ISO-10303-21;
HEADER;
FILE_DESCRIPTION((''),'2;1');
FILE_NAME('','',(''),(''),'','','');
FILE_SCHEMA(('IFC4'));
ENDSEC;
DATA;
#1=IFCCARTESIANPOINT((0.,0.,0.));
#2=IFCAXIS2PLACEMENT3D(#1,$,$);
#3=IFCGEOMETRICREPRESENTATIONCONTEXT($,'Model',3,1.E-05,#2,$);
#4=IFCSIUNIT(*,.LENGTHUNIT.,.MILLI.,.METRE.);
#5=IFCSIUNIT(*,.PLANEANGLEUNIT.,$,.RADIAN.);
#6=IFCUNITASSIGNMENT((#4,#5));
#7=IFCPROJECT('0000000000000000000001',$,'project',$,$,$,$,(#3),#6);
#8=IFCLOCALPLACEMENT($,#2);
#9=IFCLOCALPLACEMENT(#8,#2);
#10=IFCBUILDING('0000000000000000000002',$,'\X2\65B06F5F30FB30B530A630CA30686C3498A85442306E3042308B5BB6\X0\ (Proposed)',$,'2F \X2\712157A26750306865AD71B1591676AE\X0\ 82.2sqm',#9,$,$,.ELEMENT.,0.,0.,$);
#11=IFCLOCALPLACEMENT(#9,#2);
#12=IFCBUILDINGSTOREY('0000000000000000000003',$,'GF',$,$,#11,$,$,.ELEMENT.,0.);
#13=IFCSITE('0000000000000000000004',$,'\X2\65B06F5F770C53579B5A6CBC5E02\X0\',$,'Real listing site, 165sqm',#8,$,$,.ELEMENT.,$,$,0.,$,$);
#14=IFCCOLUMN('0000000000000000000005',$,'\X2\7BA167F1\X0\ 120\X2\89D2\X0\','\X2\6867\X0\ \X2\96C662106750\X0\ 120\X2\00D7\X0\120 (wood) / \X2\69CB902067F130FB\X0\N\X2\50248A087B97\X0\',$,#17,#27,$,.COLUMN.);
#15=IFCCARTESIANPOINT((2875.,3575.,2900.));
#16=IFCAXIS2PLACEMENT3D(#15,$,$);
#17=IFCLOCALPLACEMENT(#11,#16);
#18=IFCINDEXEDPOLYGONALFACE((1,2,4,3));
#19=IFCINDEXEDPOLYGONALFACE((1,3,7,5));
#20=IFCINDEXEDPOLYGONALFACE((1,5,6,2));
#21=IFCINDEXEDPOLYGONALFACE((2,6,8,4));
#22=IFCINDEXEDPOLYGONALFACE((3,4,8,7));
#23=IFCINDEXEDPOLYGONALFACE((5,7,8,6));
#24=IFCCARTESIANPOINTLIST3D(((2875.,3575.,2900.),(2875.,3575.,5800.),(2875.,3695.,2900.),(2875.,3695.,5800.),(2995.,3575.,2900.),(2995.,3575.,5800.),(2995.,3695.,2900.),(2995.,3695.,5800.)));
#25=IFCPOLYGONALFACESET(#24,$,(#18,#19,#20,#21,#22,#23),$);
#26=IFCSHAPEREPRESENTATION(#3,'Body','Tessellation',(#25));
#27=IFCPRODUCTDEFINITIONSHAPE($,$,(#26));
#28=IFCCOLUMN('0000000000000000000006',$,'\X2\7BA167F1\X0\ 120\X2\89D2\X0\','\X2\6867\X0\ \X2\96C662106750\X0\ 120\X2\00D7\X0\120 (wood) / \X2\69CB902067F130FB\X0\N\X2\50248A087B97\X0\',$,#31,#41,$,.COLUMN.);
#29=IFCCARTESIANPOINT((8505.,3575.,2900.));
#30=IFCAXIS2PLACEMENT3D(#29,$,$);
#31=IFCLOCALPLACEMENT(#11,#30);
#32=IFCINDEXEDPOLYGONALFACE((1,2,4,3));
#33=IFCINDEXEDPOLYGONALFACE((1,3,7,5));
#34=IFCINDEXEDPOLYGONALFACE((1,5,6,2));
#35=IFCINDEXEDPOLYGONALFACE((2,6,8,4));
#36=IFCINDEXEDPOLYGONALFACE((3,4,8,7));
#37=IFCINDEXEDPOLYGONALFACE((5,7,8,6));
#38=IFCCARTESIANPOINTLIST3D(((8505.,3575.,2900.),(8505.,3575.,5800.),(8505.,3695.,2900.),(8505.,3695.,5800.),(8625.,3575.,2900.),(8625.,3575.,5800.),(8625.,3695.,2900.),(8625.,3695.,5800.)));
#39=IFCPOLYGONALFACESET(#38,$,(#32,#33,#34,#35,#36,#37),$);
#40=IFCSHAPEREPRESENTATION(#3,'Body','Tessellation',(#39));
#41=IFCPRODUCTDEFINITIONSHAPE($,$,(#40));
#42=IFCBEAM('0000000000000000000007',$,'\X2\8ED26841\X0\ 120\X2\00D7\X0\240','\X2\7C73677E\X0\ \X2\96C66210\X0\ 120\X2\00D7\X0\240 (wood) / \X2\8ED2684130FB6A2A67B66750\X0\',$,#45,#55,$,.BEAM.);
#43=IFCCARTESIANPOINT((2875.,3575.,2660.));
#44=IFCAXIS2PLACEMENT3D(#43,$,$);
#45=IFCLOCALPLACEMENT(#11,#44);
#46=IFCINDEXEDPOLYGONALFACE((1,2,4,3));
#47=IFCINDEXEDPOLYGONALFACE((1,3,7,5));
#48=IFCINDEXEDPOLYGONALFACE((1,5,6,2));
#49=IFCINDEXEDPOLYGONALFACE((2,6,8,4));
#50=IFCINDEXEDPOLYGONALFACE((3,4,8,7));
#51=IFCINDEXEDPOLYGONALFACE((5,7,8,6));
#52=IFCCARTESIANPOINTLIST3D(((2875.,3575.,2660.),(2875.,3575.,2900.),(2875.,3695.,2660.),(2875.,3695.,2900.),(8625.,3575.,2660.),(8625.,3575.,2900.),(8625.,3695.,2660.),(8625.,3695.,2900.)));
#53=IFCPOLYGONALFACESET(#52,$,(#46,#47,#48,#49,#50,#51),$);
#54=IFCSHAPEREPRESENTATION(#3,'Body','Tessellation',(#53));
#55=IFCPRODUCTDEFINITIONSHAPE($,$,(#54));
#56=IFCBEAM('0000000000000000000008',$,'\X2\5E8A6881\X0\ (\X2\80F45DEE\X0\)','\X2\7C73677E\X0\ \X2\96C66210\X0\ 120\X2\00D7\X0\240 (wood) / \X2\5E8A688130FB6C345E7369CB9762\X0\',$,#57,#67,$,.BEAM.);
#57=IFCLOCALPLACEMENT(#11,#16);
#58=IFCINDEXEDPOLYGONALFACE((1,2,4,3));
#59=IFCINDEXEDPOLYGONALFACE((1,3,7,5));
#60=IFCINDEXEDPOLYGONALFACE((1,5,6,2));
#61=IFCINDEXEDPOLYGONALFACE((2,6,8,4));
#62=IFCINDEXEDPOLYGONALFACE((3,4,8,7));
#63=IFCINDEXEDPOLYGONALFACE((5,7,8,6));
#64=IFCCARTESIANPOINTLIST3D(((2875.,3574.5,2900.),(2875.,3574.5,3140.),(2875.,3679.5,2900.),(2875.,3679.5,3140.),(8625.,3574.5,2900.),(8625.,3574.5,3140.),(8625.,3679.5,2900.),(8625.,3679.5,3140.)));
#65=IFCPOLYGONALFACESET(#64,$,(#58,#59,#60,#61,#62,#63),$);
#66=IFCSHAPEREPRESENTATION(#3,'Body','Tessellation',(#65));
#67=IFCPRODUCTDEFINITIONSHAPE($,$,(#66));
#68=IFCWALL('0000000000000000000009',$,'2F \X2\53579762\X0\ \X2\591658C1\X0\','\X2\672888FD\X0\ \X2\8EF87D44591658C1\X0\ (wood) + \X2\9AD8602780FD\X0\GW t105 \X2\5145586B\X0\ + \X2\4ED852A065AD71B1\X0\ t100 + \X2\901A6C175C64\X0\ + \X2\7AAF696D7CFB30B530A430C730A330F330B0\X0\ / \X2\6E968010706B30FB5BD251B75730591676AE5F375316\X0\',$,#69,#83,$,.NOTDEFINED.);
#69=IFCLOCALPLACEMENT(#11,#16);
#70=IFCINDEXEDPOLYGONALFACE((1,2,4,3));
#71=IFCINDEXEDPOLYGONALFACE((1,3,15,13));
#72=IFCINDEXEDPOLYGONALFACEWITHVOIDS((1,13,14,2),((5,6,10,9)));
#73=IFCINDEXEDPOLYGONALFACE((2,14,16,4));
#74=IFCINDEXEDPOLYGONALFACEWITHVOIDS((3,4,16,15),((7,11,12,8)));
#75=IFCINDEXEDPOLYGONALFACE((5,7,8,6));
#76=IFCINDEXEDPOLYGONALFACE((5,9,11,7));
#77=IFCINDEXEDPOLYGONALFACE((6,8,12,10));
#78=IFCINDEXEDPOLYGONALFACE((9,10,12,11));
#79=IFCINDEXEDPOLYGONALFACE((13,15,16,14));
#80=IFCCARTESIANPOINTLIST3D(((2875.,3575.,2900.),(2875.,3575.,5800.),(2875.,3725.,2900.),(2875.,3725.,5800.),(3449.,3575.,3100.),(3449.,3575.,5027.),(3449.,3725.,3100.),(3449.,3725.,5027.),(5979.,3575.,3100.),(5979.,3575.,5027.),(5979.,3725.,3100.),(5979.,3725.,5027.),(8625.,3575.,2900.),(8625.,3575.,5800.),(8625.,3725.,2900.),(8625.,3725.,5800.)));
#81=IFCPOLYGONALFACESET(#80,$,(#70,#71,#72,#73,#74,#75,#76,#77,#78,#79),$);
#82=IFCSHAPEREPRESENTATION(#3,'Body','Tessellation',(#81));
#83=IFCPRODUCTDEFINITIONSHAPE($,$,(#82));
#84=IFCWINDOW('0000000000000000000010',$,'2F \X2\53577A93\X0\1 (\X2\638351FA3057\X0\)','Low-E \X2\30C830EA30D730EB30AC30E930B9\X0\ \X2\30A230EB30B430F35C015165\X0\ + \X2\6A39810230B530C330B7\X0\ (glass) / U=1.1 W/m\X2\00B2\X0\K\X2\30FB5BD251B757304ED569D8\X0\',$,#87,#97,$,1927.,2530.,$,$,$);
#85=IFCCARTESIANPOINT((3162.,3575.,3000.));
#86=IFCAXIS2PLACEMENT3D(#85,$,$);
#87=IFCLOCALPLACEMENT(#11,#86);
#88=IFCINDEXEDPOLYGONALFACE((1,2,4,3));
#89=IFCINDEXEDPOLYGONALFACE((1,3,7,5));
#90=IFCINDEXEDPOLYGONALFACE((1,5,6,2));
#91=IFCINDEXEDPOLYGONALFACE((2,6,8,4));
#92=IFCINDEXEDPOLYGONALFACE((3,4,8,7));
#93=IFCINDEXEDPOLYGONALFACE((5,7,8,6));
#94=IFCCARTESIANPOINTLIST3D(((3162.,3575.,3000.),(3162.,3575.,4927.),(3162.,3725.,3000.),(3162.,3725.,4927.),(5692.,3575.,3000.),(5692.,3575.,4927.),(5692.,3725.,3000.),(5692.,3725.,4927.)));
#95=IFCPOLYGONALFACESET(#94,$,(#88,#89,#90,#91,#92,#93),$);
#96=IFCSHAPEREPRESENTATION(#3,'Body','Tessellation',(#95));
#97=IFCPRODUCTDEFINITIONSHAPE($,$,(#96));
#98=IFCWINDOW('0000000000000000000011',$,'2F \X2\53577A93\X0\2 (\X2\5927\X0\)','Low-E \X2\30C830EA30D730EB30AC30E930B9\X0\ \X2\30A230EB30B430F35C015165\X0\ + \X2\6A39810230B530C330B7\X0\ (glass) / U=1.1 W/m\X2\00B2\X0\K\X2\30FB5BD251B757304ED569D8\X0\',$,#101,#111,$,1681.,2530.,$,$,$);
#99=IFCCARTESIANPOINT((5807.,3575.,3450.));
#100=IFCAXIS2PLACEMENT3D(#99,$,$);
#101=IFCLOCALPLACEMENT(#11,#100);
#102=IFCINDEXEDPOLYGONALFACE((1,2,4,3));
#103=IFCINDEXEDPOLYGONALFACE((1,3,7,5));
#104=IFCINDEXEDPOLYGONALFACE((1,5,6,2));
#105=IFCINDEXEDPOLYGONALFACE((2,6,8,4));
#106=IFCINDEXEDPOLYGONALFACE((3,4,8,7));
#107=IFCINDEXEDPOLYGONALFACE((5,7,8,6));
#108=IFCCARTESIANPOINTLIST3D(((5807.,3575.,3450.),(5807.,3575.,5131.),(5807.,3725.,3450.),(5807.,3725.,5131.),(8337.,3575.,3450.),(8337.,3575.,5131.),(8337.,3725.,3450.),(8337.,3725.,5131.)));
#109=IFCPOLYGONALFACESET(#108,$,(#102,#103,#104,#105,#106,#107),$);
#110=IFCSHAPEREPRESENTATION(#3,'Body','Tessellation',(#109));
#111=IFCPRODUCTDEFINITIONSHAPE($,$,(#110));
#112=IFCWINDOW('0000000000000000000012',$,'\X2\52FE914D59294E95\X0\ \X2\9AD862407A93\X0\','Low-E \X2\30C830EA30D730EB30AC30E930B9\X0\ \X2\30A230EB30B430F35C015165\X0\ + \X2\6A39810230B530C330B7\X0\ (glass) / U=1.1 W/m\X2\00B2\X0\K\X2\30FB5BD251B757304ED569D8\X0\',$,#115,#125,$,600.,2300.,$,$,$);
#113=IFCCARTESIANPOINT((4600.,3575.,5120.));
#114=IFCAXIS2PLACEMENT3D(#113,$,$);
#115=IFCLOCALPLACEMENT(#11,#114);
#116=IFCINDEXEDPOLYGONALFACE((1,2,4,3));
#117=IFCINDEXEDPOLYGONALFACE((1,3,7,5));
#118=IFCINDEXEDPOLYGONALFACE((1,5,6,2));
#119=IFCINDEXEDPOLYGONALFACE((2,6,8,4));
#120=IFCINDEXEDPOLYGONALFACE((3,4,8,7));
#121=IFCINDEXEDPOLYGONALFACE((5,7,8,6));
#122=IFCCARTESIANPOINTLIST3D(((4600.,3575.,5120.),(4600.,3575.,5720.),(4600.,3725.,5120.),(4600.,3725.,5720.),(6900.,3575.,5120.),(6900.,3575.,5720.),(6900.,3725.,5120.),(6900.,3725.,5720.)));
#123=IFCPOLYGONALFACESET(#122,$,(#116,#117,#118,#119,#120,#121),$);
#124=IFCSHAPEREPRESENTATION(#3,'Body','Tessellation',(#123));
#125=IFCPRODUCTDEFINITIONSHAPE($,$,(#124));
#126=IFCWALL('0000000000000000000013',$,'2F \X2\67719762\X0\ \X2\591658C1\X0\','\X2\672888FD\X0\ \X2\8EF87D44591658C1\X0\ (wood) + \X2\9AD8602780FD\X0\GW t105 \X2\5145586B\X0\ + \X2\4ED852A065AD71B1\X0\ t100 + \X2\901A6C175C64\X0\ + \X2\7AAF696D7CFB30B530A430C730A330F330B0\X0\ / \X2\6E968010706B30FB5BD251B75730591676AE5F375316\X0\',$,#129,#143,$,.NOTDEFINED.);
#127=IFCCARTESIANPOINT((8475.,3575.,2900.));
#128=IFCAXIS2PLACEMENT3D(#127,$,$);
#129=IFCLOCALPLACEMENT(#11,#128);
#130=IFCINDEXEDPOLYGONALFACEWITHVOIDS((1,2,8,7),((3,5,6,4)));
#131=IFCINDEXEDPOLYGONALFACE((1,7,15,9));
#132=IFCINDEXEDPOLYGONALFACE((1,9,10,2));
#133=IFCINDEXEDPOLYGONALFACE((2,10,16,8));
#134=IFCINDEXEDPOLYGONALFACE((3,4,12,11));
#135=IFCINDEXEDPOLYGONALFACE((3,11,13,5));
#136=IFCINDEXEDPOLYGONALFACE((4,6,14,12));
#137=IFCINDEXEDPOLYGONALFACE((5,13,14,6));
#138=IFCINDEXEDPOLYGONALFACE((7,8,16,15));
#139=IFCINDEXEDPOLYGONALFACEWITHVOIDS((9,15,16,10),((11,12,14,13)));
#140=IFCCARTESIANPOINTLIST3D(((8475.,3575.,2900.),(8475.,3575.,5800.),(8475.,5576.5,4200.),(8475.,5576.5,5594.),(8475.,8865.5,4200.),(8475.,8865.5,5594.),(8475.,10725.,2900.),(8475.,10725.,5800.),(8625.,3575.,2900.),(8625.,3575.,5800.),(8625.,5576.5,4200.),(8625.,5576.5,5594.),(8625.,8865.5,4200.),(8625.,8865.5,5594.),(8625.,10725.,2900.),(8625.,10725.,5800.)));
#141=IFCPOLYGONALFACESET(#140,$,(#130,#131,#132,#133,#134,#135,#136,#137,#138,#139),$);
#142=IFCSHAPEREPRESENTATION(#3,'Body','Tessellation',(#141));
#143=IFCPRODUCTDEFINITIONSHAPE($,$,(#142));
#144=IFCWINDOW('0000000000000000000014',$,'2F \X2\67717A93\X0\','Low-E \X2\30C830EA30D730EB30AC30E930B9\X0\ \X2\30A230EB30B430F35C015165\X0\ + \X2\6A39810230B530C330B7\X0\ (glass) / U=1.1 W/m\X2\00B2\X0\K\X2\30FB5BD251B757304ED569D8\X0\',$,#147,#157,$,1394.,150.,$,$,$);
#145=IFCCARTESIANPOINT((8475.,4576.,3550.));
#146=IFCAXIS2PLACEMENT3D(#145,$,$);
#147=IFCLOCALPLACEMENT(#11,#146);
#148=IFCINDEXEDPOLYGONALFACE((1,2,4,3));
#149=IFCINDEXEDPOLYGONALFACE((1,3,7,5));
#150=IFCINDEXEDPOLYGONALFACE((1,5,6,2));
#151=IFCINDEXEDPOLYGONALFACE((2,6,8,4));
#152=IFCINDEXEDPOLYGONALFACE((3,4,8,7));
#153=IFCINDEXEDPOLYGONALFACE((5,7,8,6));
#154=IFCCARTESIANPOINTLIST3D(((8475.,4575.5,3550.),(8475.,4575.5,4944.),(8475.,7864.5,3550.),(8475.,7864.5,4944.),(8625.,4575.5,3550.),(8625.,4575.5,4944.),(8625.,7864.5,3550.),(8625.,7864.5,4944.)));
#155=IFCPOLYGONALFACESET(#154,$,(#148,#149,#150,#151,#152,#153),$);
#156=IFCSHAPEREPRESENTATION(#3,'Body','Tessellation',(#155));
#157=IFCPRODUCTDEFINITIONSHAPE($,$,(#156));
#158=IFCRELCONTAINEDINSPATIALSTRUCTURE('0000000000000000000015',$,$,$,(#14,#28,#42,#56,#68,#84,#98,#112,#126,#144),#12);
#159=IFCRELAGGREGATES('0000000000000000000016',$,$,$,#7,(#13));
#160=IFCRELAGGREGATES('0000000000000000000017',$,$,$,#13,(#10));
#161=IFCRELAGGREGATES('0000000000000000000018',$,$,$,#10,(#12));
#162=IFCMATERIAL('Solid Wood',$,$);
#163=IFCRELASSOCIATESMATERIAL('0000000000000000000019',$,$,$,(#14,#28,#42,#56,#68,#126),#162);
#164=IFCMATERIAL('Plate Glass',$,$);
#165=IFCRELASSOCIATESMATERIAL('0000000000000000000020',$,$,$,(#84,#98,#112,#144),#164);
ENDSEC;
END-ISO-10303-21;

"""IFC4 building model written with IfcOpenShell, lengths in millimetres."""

from ifc_helpers import new_model, si_unit, frame, frame_2d, origin, place, context, project, spatial, rectangle, extrude, material, element, fill, save


model = new_model("IFC4")

# Units and contexts
model_context = context("Model", 3, precision=1e-05, world=origin())
ifc_project = project(units=[si_unit("LENGTHUNIT", "METRE", prefix="MILLI"), si_unit("PLANEANGLEUNIT", "RADIAN")], contexts=[model_context])

# Site, building, storey
site_placement = place(None, origin())
site = spatial("IfcSite", under=ifc_project, at=site_placement, Name="新潟県南魚沼市", ObjectType="Real listing site, 165sqm", CompositionType="ELEMENT", RefElevation=0.0)
building_placement = place(site_placement, origin())
building = spatial("IfcBuilding", under=site, at=building_placement, Name="新潟・サウナと水風呂のある家 (Proposed)", ObjectType="2F 無垢材と断熱外皮 82.2sqm", CompositionType="ELEMENT", ElevationOfRefHeight=0.0, ElevationOfTerrain=0.0)
storey_placement = place(building_placement, origin())
storey = spatial("IfcBuildingStorey", under=building, at=storey_placement, Name="GF", CompositionType="ELEMENT", Elevation=0.0)

# Columns
ifc_material_1 = material(Name="Solid Wood")
column_1_placement = place(storey_placement, frame((2875.0, 3575.0, 2900.0)))
element("IfcColumn", 1, at=column_1_placement, inside=storey, material=ifc_material_1, Name="管柱 120角", Description="桧 集成材 120×120 (wood) / 構造柱・N値計算", PredefinedType="COLUMN", context=model_context, shape_type="SweptSolid", body=[
    extrude(rectangle(XDim=120.0, YDim=120.0, at=frame_2d((60.0, 60.0))), frame((2875.0, 3575.0, 2900.0)), (0.0, 0.0, 1.0), 2900.0),
])
column_2_placement = place(storey_placement, frame((8505.0, 3575.0, 2900.0)))
element("IfcColumn", 2, at=column_2_placement, inside=storey, material=ifc_material_1, Name="管柱 120角", Description="桧 集成材 120×120 (wood) / 構造柱・N値計算", PredefinedType="COLUMN", context=model_context, shape_type="SweptSolid", body=[
    extrude(rectangle(XDim=120.0, YDim=120.0, at=frame_2d((60.0, 60.0))), frame((8505.0, 3575.0, 2900.0)), (0.0, 0.0, 1.0), 2900.0),
])

# Beams
beam_1_placement = place(storey_placement, frame((2875.0, 3575.0, 2660.0)))
element("IfcBeam", 3, at=beam_1_placement, inside=storey, material=ifc_material_1, Name="軒桁 120×240", Description="米松 集成 120×240 (wood) / 軒桁・横架材", PredefinedType="BEAM", context=model_context, shape_type="SweptSolid", body=[
    extrude(rectangle(XDim=5750.0, YDim=120.0, at=frame_2d((2875.0, 60.0))), frame((2875.0, 3575.0, 2660.0)), (0.0, 0.0, 1.0), 240.0),
])
beam_2_placement = place(storey_placement, frame((2875.0, 3575.0, 2900.0)))
element("IfcBeam", 4, at=beam_2_placement, inside=storey, material=ifc_material_1, Name="床梁 (胴差)", Description="米松 集成 120×240 (wood) / 床梁・水平構面", PredefinedType="BEAM", context=model_context, shape_type="SweptSolid", body=[
    extrude(rectangle(XDim=5750.0, YDim=105.0, at=frame_2d((2875.0, 52.0))), frame((2875.0, 3575.0, 2900.0)), (0.0, 0.0, 1.0), 240.0),
])

# Wall, openings, windows
wall_1_placement = place(storey_placement, frame((2875.0, 3575.0, 2900.0)))
wall_1 = element("IfcWall", 5, at=wall_1_placement, inside=storey, material=ifc_material_1, Name="2F 南面 外壁", Description="木製 軸組外壁 (wood) + 高性能GW t105 充填 + 付加断熱 t100 + 通気層 + 窯業系サイディング / 準耐火・寒冷地外皮強化", PredefinedType="NOTDEFINED", context=model_context, shape_type="SweptSolid", body=[
    extrude(rectangle(XDim=5750.0, YDim=150.0, at=frame_2d((2875.0, 75.0))), frame((2875.0, 3575.0, 2900.0)), (0.0, 0.0, 1.0), 2900.0),
])
opening_1_placement = place(storey_placement, frame((3162.0, 3575.0, 3000.0)))
opening_1 = element("IfcOpeningElement", 6, at=opening_1_placement, cuts=wall_1, PredefinedType="NOTDEFINED", context=model_context, shape_type="SweptSolid", body=[
    extrude(rectangle(XDim=2530.0, YDim=150.0, at=frame_2d((1265.0, 75.0))), frame((3162.0, 3575.0, 3000.0)), (0.0, 0.0, 1.0), 1927.0),
])
opening_2_placement = place(storey_placement, frame((5807.0, 3575.0, 3450.0)))
opening_2 = element("IfcOpeningElement", 7, at=opening_2_placement, cuts=wall_1, PredefinedType="NOTDEFINED", context=model_context, shape_type="SweptSolid", body=[
    extrude(rectangle(XDim=2530.0, YDim=150.0, at=frame_2d((1265.0, 75.0))), frame((5807.0, 3575.0, 3450.0)), (0.0, 0.0, 1.0), 1681.0),
])
opening_3_placement = place(storey_placement, frame((4600.0, 3575.0, 5120.0)))
opening_3 = element("IfcOpeningElement", 8, at=opening_3_placement, cuts=wall_1, PredefinedType="NOTDEFINED", context=model_context, shape_type="SweptSolid", body=[
    extrude(rectangle(XDim=2300.0, YDim=150.0, at=frame_2d((1150.0, 75.0))), frame((4600.0, 3575.0, 5120.0)), (0.0, 0.0, 1.0), 600.0),
])
ifc_material_2 = material(Name="Plate Glass")
window_1_placement = place(storey_placement, frame((3162.0, 3575.0, 3000.0)))
window_1 = element("IfcWindow", 9, at=window_1_placement, inside=storey, material=ifc_material_2, Name="2F 南窓1 (掃出し)", Description="Low-E トリプルガラス アルゴン封入 + 樹脂サッシ (glass) / U=1.1 W/m²K・寒冷地仕様", OverallHeight=1927.0, OverallWidth=2530.0, context=model_context, shape_type="SweptSolid", body=[
    extrude(rectangle(XDim=2530.0, YDim=150.0, at=frame_2d((1265.0, 75.0))), frame((3162.0, 3575.0, 3000.0)), (0.0, 0.0, 1.0), 1927.0),
])
fill(opening_1, window_1)
window_2_placement = place(storey_placement, frame((5807.0, 3575.0, 3450.0)))
window_2 = element("IfcWindow", 10, at=window_2_placement, inside=storey, material=ifc_material_2, Name="2F 南窓2 (大)", Description="Low-E トリプルガラス アルゴン封入 + 樹脂サッシ (glass) / U=1.1 W/m²K・寒冷地仕様", OverallHeight=1681.0, OverallWidth=2530.0, context=model_context, shape_type="SweptSolid", body=[
    extrude(rectangle(XDim=2530.0, YDim=150.0, at=frame_2d((1265.0, 75.0))), frame((5807.0, 3575.0, 3450.0)), (0.0, 0.0, 1.0), 1681.0),
])
fill(opening_2, window_2)
window_3_placement = place(storey_placement, frame((4600.0, 3575.0, 5120.0)))
window_3 = element("IfcWindow", 11, at=window_3_placement, inside=storey, material=ifc_material_2, Name="勾配天井 高所窓", Description="Low-E トリプルガラス アルゴン封入 + 樹脂サッシ (glass) / U=1.1 W/m²K・寒冷地仕様", OverallHeight=600.0, OverallWidth=2300.0, context=model_context, shape_type="SweptSolid", body=[
    extrude(rectangle(XDim=2300.0, YDim=150.0, at=frame_2d((1150.0, 75.0))), frame((4600.0, 3575.0, 5120.0)), (0.0, 0.0, 1.0), 600.0),
])
fill(opening_3, window_3)

# Wall, opening, window
wall_2_placement = place(storey_placement, frame((8475.0, 3575.0, 2900.0)))
wall_2 = element("IfcWall", 12, at=wall_2_placement, inside=storey, material=ifc_material_1, Name="2F 東面 外壁", Description="木製 軸組外壁 (wood) + 高性能GW t105 充填 + 付加断熱 t100 + 通気層 + 窯業系サイディング / 準耐火・寒冷地外皮強化", PredefinedType="NOTDEFINED", context=model_context, shape_type="SweptSolid", body=[
    extrude(rectangle(XDim=150.0, YDim=7150.0, at=frame_2d((75.0, 3575.0))), frame((8475.0, 3575.0, 2900.0)), (0.0, 0.0, 1.0), 2900.0),
])
opening_4_placement = place(storey_placement, frame((8475.0, 4576.0, 3550.0)))
opening_4 = element("IfcOpeningElement", 13, at=opening_4_placement, cuts=wall_2, PredefinedType="NOTDEFINED", context=model_context, shape_type="SweptSolid", body=[
    extrude(rectangle(XDim=150.0, YDim=3289.0, at=frame_2d((75.0, 1644.0))), frame((8475.0, 4576.0, 3550.0)), (0.0, 0.0, 1.0), 1394.0),
])
window_4_placement = place(storey_placement, frame((8475.0, 4576.0, 3550.0)))
window_4 = element("IfcWindow", 14, at=window_4_placement, inside=storey, material=ifc_material_2, Name="2F 東窓", Description="Low-E トリプルガラス アルゴン封入 + 樹脂サッシ (glass) / U=1.1 W/m²K・寒冷地仕様", OverallHeight=1394.0, OverallWidth=150.0, context=model_context, shape_type="SweptSolid", body=[
    extrude(rectangle(XDim=150.0, YDim=3289.0, at=frame_2d((75.0, 1644.0))), frame((8475.0, 4576.0, 3550.0)), (0.0, 0.0, 1.0), 1394.0),
])
fill(opening_4, window_4)

save(model, "model.ifc")
